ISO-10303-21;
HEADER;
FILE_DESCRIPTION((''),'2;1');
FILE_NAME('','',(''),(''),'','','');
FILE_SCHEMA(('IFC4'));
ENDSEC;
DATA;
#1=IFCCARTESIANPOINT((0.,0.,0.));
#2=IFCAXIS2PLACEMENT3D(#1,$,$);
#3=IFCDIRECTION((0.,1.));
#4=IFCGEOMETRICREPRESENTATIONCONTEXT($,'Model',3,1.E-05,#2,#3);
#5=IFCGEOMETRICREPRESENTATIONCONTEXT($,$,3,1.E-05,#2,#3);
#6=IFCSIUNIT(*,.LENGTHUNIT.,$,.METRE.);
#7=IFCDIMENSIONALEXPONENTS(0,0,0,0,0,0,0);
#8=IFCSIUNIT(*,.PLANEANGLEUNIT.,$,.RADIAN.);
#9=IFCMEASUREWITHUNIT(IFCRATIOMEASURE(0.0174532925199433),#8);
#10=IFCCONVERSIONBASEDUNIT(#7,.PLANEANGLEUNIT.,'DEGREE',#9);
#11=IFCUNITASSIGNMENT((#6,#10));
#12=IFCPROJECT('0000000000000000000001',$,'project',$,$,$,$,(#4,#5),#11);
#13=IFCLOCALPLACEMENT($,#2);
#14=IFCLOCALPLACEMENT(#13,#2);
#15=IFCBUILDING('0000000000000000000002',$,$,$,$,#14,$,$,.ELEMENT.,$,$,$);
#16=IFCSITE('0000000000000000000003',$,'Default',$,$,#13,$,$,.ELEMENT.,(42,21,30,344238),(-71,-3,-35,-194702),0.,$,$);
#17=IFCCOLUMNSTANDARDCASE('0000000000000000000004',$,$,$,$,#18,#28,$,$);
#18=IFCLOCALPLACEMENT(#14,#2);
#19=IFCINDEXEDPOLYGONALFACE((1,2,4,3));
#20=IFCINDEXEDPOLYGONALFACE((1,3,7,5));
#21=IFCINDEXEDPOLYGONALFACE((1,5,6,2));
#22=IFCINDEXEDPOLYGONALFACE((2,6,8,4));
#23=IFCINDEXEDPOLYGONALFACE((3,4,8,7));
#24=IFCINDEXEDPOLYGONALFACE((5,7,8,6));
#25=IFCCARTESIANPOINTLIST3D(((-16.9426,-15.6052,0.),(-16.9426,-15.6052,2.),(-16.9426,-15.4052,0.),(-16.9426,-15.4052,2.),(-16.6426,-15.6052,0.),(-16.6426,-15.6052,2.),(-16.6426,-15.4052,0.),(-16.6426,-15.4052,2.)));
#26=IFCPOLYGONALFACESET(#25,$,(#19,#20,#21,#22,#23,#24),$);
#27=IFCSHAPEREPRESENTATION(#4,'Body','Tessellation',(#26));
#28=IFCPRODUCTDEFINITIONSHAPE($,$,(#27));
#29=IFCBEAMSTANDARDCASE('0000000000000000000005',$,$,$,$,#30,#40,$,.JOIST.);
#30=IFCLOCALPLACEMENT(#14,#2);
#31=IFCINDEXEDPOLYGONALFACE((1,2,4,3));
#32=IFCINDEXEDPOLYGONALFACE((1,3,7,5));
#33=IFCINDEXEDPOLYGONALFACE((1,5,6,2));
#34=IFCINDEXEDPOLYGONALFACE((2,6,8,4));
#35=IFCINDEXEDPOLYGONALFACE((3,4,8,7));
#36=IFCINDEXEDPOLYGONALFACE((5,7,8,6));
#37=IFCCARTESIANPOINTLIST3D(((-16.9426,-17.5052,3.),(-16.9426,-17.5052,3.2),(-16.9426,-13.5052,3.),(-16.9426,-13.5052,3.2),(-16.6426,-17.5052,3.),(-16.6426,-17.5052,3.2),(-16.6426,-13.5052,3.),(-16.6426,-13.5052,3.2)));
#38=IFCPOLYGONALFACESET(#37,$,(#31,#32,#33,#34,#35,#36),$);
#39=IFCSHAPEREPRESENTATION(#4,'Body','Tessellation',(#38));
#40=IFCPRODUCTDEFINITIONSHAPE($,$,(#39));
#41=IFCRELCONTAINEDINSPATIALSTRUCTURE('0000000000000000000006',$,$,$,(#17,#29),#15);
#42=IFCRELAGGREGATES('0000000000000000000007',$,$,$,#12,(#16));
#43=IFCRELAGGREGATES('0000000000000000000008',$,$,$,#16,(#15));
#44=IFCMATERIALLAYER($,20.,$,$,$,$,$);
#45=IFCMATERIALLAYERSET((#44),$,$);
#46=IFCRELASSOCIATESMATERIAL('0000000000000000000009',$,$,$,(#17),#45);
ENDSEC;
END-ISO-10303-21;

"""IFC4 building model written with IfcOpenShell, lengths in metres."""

from ifc_helpers import new_model, entity, si_unit, converted_unit, direction, frame, origin, origin_with_axes, origin_2d, place, context, project, spatial, rectangle, extrude, layer, layer_set, layer_usage, element, save


model = new_model("IFC4")

# Units and contexts
model_context = context("Model", 3, precision=1e-05, world=origin(), true_north=direction((0.0, 1.0)))
context_of_model = context(None, 3, precision=1e-05, world=origin(), true_north=direction((0.0, 1.0)))
ifc_project = project(units=[si_unit("LENGTHUNIT", "METRE"), converted_unit("PLANEANGLEUNIT", "DEGREE", entity("IfcRatioMeasure", 0.0174532925199433), si_unit("PLANEANGLEUNIT", "RADIAN"), dimensions=[0, 0, 0, 0, 0, 0, 0])], contexts=[model_context, context_of_model])

# Site, building
site_placement = place(None, origin())
site = spatial("IfcSite", under=ifc_project, at=site_placement, Name="Default", CompositionType="ELEMENT", RefLatitude=(42, 21, 30, 344238), RefLongitude=(-71, -3, -35, -194702), RefElevation=0.0)
building_placement = place(site_placement, origin())
building = spatial("IfcBuilding", under=site, at=building_placement, CompositionType="ELEMENT")

# Column
ifc_layer_1 = layer(None, 20.0)
ifc_layer_set_1 = layer_set([ifc_layer_1])
ifc_layer_usage_1 = layer_usage(ifc_layer_set_1, "AXIS2", "POSITIVE", 150.0)
placement_1 = place(building_placement, origin())
placement_2 = place(placement_1, frame((-16.7926, -15.5052, 0.0), z_axis=(0.0, 0.0, 1.0), x_axis=(0.0, 1.0, 0.0)))
column_1_placement = place(placement_2, origin_with_axes())
element("IfcColumnStandardCase", 1, at=column_1_placement, inside=building, material=ifc_layer_usage_1, context=model_context, shape_type="SweptSolid", body=[
    extrude(rectangle(XDim=0.2, YDim=0.3, at=origin_2d()), origin(), (0.0, 0.0, 1.0), 2.0),
])

# Beam
beam_placement = place(placement_2, frame((0.0, 0.0, 3.0), z_axis=(0.0, 0.0, 1.0), x_axis=(1.0, 0.0, 0.0)))
element("IfcBeamStandardCase", 2, at=beam_placement, inside=building, PredefinedType="JOIST", context=model_context, shape_type="SweptSolid", body=[
    extrude(rectangle(XDim=4.0, YDim=0.3), origin(), (0.0, 0.0, 1.0), 0.2),
])

save(model, "model.ifc")
